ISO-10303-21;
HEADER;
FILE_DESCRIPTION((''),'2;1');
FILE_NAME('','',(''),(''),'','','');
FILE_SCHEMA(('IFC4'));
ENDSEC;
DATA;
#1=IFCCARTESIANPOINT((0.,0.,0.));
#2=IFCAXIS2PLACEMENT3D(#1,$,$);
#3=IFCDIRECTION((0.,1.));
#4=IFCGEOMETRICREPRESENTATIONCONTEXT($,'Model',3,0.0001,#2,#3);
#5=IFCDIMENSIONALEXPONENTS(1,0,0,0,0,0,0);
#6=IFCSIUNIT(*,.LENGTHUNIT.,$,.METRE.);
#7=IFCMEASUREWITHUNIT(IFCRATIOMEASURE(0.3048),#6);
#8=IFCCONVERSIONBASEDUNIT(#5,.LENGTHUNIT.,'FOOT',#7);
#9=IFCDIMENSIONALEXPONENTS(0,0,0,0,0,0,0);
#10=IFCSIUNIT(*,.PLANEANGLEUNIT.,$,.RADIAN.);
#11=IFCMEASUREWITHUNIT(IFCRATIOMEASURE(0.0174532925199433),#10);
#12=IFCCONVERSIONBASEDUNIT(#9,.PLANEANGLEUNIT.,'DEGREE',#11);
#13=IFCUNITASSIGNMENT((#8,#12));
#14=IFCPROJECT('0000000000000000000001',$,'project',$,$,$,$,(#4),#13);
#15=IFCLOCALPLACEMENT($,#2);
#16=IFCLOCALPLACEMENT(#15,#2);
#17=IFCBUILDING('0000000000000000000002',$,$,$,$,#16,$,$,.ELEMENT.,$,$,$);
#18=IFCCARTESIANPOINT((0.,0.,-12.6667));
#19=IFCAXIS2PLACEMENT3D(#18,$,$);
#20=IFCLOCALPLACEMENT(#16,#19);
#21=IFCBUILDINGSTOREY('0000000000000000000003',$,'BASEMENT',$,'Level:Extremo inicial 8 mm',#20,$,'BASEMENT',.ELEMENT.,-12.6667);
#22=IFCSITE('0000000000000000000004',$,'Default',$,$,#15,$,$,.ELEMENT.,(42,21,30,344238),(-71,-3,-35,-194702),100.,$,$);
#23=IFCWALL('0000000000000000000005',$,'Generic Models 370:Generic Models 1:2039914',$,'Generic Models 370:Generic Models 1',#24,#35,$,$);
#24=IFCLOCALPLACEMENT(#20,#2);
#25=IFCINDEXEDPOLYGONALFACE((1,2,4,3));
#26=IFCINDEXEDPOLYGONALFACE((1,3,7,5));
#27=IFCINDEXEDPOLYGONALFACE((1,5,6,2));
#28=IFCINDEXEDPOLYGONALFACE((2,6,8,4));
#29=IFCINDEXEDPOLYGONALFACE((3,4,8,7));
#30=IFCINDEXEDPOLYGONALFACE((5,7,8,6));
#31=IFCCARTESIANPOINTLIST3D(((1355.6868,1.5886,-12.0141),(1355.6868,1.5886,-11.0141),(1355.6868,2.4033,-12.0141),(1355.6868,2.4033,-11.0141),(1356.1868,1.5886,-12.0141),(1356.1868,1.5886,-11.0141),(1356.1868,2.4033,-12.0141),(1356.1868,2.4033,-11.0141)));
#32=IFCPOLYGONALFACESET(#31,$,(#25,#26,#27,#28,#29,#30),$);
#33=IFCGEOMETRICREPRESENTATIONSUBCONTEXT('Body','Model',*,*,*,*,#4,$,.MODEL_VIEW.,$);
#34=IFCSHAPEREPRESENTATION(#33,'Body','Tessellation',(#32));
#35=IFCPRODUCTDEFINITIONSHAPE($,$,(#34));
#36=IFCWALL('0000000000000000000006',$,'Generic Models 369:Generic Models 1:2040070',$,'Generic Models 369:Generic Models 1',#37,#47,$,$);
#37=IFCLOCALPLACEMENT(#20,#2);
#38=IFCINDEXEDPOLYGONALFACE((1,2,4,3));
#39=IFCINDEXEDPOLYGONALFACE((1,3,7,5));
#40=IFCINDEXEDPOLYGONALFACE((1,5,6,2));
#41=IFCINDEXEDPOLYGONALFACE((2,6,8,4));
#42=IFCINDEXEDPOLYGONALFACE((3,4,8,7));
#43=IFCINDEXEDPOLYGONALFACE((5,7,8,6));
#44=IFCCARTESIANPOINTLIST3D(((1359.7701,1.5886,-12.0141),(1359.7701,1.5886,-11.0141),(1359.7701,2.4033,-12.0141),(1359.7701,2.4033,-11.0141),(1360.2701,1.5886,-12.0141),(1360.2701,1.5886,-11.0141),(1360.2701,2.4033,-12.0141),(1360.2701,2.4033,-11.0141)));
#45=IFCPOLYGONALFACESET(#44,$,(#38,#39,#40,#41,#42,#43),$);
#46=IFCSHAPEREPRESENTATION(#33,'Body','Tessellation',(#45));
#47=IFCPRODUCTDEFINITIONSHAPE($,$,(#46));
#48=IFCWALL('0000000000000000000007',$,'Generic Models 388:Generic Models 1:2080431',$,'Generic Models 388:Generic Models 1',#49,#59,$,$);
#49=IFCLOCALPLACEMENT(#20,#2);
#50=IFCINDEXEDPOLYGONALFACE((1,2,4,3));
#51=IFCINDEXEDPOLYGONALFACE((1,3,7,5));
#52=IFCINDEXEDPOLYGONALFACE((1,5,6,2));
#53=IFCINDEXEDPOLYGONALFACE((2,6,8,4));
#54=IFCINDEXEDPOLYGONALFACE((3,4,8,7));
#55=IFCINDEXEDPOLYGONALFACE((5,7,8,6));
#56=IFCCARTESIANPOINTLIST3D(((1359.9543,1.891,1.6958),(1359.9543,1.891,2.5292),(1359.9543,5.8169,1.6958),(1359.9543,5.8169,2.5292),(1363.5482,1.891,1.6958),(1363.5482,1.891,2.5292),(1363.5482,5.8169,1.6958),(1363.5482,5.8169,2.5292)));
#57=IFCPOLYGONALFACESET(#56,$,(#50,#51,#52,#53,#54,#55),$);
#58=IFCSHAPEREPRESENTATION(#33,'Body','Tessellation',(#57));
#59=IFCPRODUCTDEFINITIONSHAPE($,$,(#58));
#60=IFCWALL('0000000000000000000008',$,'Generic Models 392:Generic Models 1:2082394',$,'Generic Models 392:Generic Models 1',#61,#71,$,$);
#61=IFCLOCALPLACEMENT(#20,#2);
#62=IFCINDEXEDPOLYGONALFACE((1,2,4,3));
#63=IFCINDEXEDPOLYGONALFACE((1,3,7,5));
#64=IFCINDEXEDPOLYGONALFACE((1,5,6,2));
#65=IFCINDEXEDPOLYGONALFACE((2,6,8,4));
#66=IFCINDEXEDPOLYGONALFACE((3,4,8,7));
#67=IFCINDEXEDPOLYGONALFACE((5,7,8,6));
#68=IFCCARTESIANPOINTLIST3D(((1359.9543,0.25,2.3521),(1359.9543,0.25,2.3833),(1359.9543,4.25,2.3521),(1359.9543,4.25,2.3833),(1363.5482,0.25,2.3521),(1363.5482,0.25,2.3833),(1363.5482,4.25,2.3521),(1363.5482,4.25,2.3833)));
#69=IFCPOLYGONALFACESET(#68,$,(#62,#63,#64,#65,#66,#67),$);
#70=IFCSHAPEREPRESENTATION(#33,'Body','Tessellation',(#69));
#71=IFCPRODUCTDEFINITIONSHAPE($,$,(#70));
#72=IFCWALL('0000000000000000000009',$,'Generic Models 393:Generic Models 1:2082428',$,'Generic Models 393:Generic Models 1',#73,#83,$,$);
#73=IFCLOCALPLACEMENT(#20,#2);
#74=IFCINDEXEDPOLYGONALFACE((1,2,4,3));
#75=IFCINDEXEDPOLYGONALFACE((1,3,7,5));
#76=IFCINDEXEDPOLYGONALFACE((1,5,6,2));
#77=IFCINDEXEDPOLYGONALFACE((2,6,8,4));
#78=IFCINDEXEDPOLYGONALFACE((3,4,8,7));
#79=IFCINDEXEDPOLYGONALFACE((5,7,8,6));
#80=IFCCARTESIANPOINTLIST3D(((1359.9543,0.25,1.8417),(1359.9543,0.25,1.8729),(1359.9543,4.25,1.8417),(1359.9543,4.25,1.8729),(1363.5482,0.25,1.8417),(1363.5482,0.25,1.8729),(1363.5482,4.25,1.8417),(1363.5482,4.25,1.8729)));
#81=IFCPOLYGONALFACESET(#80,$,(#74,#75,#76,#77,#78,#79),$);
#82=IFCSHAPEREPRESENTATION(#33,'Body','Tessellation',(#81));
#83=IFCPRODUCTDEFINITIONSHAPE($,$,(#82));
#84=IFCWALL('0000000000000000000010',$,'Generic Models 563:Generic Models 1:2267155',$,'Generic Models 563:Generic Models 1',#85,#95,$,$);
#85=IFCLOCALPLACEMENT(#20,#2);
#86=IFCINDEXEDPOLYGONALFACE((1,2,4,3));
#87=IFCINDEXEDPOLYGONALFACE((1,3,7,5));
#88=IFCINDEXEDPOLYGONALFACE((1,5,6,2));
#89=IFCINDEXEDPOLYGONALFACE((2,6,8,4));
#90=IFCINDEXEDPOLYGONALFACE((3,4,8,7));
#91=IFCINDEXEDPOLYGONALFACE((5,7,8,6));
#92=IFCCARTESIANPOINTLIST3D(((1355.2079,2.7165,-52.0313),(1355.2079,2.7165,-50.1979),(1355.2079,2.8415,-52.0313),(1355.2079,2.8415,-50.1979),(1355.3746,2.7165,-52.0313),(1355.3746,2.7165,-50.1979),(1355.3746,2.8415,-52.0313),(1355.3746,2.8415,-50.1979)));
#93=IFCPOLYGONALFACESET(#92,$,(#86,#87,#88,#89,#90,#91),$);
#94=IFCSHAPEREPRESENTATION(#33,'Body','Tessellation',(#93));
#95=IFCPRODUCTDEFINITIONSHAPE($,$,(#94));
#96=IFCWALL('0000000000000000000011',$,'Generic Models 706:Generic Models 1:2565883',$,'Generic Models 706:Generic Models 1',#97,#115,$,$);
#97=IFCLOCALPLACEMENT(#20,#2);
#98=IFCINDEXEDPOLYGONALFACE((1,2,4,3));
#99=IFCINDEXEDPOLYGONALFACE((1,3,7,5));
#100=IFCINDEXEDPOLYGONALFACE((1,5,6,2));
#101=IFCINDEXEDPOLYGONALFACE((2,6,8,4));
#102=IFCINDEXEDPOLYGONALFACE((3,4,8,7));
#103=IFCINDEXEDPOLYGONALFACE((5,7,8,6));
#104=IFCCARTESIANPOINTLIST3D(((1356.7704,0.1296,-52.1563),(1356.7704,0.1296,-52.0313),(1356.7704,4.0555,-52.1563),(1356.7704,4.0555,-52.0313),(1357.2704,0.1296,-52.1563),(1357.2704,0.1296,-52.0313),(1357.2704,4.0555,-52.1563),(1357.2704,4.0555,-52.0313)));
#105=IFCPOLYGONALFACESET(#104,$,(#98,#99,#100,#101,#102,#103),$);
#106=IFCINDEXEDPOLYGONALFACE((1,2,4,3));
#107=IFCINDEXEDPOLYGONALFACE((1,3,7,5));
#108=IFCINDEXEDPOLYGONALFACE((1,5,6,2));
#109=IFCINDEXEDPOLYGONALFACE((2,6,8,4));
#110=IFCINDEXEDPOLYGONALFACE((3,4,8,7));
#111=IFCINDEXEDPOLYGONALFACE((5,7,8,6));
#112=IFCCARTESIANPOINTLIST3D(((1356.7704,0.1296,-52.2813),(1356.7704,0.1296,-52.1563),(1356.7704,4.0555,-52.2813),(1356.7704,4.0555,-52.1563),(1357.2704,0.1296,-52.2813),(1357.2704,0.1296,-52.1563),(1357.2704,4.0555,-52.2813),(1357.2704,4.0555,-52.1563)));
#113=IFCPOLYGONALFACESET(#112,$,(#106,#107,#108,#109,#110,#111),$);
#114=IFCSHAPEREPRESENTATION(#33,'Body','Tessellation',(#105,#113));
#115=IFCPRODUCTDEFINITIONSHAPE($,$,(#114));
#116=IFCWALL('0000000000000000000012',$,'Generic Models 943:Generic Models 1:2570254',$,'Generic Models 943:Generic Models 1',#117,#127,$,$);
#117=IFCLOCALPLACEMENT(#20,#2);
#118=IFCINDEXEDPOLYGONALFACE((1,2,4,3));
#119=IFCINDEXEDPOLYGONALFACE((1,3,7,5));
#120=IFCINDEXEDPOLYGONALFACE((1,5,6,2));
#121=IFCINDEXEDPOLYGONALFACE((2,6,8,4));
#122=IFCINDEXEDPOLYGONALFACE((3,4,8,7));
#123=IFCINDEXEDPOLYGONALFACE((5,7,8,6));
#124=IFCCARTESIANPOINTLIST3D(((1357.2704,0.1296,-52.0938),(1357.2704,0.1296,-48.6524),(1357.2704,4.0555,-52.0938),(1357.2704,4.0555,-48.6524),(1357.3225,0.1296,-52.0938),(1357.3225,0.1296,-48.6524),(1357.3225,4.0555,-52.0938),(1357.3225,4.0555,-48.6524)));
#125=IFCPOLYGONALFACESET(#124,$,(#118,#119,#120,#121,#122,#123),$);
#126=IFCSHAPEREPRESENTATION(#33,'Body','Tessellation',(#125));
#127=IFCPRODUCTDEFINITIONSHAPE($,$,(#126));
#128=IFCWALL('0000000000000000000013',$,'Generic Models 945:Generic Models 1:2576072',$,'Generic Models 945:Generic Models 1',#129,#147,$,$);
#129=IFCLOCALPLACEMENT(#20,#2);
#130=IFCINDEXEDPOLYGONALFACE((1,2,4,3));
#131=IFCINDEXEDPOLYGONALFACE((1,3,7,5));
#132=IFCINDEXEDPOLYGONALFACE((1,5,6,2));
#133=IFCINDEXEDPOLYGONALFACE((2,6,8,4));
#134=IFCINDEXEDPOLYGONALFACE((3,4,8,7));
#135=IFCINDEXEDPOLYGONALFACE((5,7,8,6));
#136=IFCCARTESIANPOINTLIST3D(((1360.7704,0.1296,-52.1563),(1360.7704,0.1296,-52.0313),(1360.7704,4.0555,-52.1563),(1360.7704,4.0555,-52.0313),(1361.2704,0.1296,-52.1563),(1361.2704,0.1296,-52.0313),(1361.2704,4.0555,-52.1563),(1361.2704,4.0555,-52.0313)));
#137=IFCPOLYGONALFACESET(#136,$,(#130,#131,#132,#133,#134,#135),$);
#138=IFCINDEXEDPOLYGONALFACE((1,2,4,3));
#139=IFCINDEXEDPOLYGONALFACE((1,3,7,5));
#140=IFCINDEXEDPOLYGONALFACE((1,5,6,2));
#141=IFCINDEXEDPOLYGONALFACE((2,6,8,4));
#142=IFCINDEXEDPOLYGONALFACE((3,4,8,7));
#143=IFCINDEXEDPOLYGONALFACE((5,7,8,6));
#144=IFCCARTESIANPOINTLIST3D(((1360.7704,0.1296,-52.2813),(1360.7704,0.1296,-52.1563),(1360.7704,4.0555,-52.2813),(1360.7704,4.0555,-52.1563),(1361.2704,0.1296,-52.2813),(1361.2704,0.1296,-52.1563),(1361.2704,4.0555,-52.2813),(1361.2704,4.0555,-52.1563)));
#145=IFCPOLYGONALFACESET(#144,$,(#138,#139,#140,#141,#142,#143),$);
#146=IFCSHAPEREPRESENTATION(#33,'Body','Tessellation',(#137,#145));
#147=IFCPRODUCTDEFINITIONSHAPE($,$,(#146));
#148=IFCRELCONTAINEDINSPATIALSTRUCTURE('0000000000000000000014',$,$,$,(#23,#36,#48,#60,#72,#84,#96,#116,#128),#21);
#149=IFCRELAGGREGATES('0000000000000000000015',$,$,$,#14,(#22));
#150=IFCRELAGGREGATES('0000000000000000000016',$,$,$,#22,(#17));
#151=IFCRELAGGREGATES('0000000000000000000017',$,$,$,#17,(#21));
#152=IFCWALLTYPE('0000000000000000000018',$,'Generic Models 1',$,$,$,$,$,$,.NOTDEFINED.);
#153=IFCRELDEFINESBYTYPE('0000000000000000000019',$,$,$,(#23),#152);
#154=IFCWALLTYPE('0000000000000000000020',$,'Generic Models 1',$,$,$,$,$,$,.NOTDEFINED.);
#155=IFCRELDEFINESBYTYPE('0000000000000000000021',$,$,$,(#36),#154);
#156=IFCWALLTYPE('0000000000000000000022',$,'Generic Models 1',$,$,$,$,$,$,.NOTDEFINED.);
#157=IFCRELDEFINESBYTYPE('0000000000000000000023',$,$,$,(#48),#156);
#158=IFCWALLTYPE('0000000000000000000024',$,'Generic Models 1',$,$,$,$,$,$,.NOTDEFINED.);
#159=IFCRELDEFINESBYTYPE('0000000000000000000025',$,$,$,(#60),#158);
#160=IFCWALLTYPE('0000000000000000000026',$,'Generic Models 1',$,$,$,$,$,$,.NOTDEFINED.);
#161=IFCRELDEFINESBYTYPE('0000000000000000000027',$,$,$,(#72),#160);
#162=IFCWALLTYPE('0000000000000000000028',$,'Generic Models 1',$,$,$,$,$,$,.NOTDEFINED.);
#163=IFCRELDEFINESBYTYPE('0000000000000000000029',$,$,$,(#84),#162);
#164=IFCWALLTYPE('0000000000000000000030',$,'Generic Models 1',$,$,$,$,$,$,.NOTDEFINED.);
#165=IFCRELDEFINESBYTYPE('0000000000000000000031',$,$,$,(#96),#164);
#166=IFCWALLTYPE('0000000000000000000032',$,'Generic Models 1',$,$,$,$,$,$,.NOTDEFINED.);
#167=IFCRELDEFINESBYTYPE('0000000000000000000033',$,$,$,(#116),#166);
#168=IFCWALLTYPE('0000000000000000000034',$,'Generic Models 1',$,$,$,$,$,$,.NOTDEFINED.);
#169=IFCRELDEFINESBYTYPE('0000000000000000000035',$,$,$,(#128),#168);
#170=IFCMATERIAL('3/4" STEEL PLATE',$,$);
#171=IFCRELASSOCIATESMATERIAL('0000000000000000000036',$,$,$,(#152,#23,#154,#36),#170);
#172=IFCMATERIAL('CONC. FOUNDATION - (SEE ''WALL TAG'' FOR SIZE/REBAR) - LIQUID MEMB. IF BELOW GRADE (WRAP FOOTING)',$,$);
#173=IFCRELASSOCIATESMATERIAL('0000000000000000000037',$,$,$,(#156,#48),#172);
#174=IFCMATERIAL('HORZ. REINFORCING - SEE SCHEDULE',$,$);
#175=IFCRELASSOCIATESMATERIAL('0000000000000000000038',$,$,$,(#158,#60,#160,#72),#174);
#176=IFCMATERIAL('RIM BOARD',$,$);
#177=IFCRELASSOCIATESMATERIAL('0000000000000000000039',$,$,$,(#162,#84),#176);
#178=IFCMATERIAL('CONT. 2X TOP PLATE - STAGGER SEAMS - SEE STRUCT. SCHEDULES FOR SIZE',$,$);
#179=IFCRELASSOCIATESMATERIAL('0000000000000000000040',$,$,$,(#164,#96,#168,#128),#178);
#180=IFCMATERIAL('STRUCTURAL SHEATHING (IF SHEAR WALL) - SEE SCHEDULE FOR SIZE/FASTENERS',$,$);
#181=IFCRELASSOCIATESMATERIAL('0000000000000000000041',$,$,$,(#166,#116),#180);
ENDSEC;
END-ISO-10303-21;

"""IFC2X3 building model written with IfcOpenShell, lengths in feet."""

from ifc_helpers import new_model, entity, si_unit, converted_unit, direction, frame, frame_2d, origin, origin_2d_with_axis, place, context, subcontext, project, spatial, rectangle, extrude, material, type_object, element, save


model = new_model("IFC2X3")

# Units and contexts
model_context = context("Model", 3, precision=0.0001, world=origin(), true_north=direction((0.0, 1.0)))
body_context = subcontext(model_context, "Body", "Model", "MODEL_VIEW")
ifc_project = project(units=[converted_unit("LENGTHUNIT", "FOOT", entity("IfcRatioMeasure", 0.3048), si_unit("LENGTHUNIT", "METRE"), dimensions=[1, 0, 0, 0, 0, 0, 0]), converted_unit("PLANEANGLEUNIT", "DEGREE", entity("IfcRatioMeasure", 0.0174532925199433), si_unit("PLANEANGLEUNIT", "RADIAN"), dimensions=[0, 0, 0, 0, 0, 0, 0])], contexts=[model_context])

# Site, building, storey
site_placement = place(None, origin())
site = spatial("IfcSite", under=ifc_project, at=site_placement, Name="Default", CompositionType="ELEMENT", RefLatitude=(42, 21, 30, 344238), RefLongitude=(-71, -3, -35, -194702), RefElevation=100.0)
building_placement = place(site_placement, origin())
building = spatial("IfcBuilding", under=site, at=building_placement, CompositionType="ELEMENT")
storey_placement = place(building_placement, frame((0.0, 0.0, -12.6667)))
storey = spatial("IfcBuildingStorey", under=building, at=storey_placement, Name="BASEMENT", ObjectType="Level:Extremo inicial 8 mm", LongName="BASEMENT", CompositionType="ELEMENT", Elevation=-12.6667)

# Walls
ifc_material_1 = material(Name="3/4\" STEEL PLATE")
wall_type_1 = type_object("IfcWallType", Name="Generic Models 1", PredefinedType="NOTDEFINED", material=ifc_material_1)
wall_1_placement = place(storey_placement, frame((1355.6868, 1.5886, -12.0141), z_axis=(0.0, 0.0, 1.0), x_axis=(0.0, 1.0, 0.0)))
element("IfcWall", 1, at=wall_1_placement, inside=storey, type_object=wall_type_1, material=ifc_material_1, Name="Generic Models 370:Generic Models 1:2039914", ObjectType="Generic Models 370:Generic Models 1", context=body_context, shape_type="SweptSolid", body=[
    extrude(rectangle(XDim=0.8147, YDim=0.5, at=origin_2d_with_axis()), frame((0.4074, -0.25, 0.0)), (0.0, 0.0, 1.0), 1.0),
])
wall_type_2 = type_object("IfcWallType", Name="Generic Models 1", PredefinedType="NOTDEFINED", material=ifc_material_1)
wall_2_placement = place(storey_placement, frame((1359.7701, 1.5886, -12.0141), z_axis=(0.0, 0.0, 1.0), x_axis=(0.0, 1.0, 0.0)))
element("IfcWall", 2, at=wall_2_placement, inside=storey, type_object=wall_type_2, material=ifc_material_1, Name="Generic Models 369:Generic Models 1:2040070", ObjectType="Generic Models 369:Generic Models 1", context=body_context, shape_type="SweptSolid", body=[
    extrude(rectangle(XDim=0.8147, YDim=0.5, at=origin_2d_with_axis()), frame((0.4074, -0.25, 0.0)), (0.0, 0.0, 1.0), 1.0),
])
ifc_material_2 = material(Name="CONC. FOUNDATION - (SEE 'WALL TAG' FOR SIZE/REBAR) - LIQUID MEMB. IF BELOW GRADE (WRAP FOOTING)")
wall_type_3 = type_object("IfcWallType", Name="Generic Models 1", PredefinedType="NOTDEFINED", material=ifc_material_2)
wall_3_placement = place(storey_placement, frame((1359.9543, 1.891, 1.6958), z_axis=(0.0, 0.0, 1.0), x_axis=(0.0, 1.0, 0.0)))
element("IfcWall", 3, at=wall_3_placement, inside=storey, type_object=wall_type_3, material=ifc_material_2, Name="Generic Models 388:Generic Models 1:2080431", ObjectType="Generic Models 388:Generic Models 1", context=body_context, shape_type="SweptSolid", body=[
    extrude(rectangle(XDim=3.9258, YDim=3.5939, at=frame_2d((0.0, 0.0), x_axis=(1.0, 0.0))), frame((1.9629, -1.797, 0.0)), (0.0, 0.0, 1.0), 0.8333),
])
ifc_material_3 = material(Name="HORZ. REINFORCING - SEE SCHEDULE")
wall_type_4 = type_object("IfcWallType", Name="Generic Models 1", PredefinedType="NOTDEFINED", material=ifc_material_3)
wall_4_placement = place(storey_placement, frame((1359.9543, 0.25, 2.3521), z_axis=(0.0, 0.0, 1.0), x_axis=(0.0, 1.0, 0.0)))
element("IfcWall", 4, at=wall_4_placement, inside=storey, type_object=wall_type_4, material=ifc_material_3, Name="Generic Models 392:Generic Models 1:2082394", ObjectType="Generic Models 392:Generic Models 1", context=body_context, shape_type="SweptSolid", body=[
    extrude(rectangle(XDim=4.0, YDim=3.5939, at=frame_2d((0.0, 0.0), x_axis=(1.0, 0.0))), frame((2.0, -1.797, 0.0)), (0.0, 0.0, 1.0), 0.0313),
])
wall_type_5 = type_object("IfcWallType", Name="Generic Models 1", PredefinedType="NOTDEFINED", material=ifc_material_3)
wall_5_placement = place(storey_placement, frame((1359.9543, 0.25, 1.8417), z_axis=(0.0, 0.0, 1.0), x_axis=(0.0, 1.0, 0.0)))
element("IfcWall", 5, at=wall_5_placement, inside=storey, type_object=wall_type_5, material=ifc_material_3, Name="Generic Models 393:Generic Models 1:2082428", ObjectType="Generic Models 393:Generic Models 1", context=body_context, shape_type="SweptSolid", body=[
    extrude(rectangle(XDim=4.0, YDim=3.5939, at=frame_2d((0.0, 0.0), x_axis=(1.0, 0.0))), frame((2.0, -1.797, 0.0)), (0.0, 0.0, 1.0), 0.0313),
])
ifc_material_4 = material(Name="RIM BOARD")
wall_type_6 = type_object("IfcWallType", Name="Generic Models 1", PredefinedType="NOTDEFINED", material=ifc_material_4)
wall_6_placement = place(storey_placement, frame((1355.2079, 2.7165, -52.0313)))
element("IfcWall", 6, at=wall_6_placement, inside=storey, type_object=wall_type_6, material=ifc_material_4, Name="Generic Models 563:Generic Models 1:2267155", ObjectType="Generic Models 563:Generic Models 1", context=body_context, shape_type="SweptSolid", body=[
    extrude(rectangle(XDim=0.125, YDim=0.1667, at=frame_2d((0.0, 0.0), x_axis=(1.0, 0.0))), frame((0.0833, 0.0625, 0.0), z_axis=(0.0, 0.0, 1.0), x_axis=(0.0, 1.0, 0.0)), (0.0, 0.0, 1.0), 1.8333),
])
ifc_material_5 = material(Name="CONT. 2X TOP PLATE - STAGGER SEAMS - SEE STRUCT. SCHEDULES FOR SIZE")
wall_type_7 = type_object("IfcWallType", Name="Generic Models 1", PredefinedType="NOTDEFINED", material=ifc_material_5)
wall_7_placement = place(storey_placement, frame((1356.7704, 0.1296, -52.2813), z_axis=(0.0, 0.0, 1.0), x_axis=(0.0, 1.0, 0.0)))
element("IfcWall", 7, at=wall_7_placement, inside=storey, type_object=wall_type_7, material=ifc_material_5, Name="Generic Models 706:Generic Models 1:2565883", ObjectType="Generic Models 706:Generic Models 1", context=body_context, shape_type="SweptSolid", body=[
    extrude(rectangle(XDim=3.9258, YDim=0.5, at=frame_2d((0.0, 0.0), x_axis=(1.0, 0.0))), frame((1.9629, -0.25, 0.125)), (0.0, 0.0, 1.0), 0.125),
    extrude(rectangle(XDim=3.9258, YDim=0.5, at=frame_2d((0.0, 0.0), x_axis=(1.0, 0.0))), frame((1.9629, -0.25, 0.0)), (0.0, 0.0, 1.0), 0.125),
])
ifc_material_6 = material(Name="STRUCTURAL SHEATHING (IF SHEAR WALL) - SEE SCHEDULE FOR SIZE/FASTENERS")
wall_type_8 = type_object("IfcWallType", Name="Generic Models 1", PredefinedType="NOTDEFINED", material=ifc_material_6)
wall_8_placement = place(storey_placement, frame((1357.2704, 0.1296, -52.0938), z_axis=(0.0, 0.0, 1.0), x_axis=(0.0, 1.0, 0.0)))
element("IfcWall", 8, at=wall_8_placement, inside=storey, type_object=wall_type_8, material=ifc_material_6, Name="Generic Models 943:Generic Models 1:2570254", ObjectType="Generic Models 943:Generic Models 1", context=body_context, shape_type="SweptSolid", body=[
    extrude(rectangle(XDim=3.9258, YDim=0.0521, at=frame_2d((0.0, 0.0), x_axis=(1.0, 0.0))), frame((1.9629, -0.026, 0.0)), (0.0, 0.0, 1.0), 3.4413),
])
wall_type_9 = type_object("IfcWallType", Name="Generic Models 1", PredefinedType="NOTDEFINED", material=ifc_material_5)
wall_9_placement = place(storey_placement, frame((1360.7704, 0.1296, -52.2813), z_axis=(0.0, 0.0, 1.0), x_axis=(0.0, 1.0, 0.0)))
element("IfcWall", 9, at=wall_9_placement, inside=storey, type_object=wall_type_9, material=ifc_material_5, Name="Generic Models 945:Generic Models 1:2576072", ObjectType="Generic Models 945:Generic Models 1", context=body_context, shape_type="SweptSolid", body=[
    extrude(rectangle(XDim=3.9258, YDim=0.5, at=frame_2d((0.0, 0.0), x_axis=(1.0, 0.0))), frame((1.9629, -0.25, 0.125)), (0.0, 0.0, 1.0), 0.125),
    extrude(rectangle(XDim=3.9258, YDim=0.5, at=frame_2d((0.0, 0.0), x_axis=(1.0, 0.0))), frame((1.9629, -0.25, 0.0)), (0.0, 0.0, 1.0), 0.125),
])

save(model, "model.ifc")
